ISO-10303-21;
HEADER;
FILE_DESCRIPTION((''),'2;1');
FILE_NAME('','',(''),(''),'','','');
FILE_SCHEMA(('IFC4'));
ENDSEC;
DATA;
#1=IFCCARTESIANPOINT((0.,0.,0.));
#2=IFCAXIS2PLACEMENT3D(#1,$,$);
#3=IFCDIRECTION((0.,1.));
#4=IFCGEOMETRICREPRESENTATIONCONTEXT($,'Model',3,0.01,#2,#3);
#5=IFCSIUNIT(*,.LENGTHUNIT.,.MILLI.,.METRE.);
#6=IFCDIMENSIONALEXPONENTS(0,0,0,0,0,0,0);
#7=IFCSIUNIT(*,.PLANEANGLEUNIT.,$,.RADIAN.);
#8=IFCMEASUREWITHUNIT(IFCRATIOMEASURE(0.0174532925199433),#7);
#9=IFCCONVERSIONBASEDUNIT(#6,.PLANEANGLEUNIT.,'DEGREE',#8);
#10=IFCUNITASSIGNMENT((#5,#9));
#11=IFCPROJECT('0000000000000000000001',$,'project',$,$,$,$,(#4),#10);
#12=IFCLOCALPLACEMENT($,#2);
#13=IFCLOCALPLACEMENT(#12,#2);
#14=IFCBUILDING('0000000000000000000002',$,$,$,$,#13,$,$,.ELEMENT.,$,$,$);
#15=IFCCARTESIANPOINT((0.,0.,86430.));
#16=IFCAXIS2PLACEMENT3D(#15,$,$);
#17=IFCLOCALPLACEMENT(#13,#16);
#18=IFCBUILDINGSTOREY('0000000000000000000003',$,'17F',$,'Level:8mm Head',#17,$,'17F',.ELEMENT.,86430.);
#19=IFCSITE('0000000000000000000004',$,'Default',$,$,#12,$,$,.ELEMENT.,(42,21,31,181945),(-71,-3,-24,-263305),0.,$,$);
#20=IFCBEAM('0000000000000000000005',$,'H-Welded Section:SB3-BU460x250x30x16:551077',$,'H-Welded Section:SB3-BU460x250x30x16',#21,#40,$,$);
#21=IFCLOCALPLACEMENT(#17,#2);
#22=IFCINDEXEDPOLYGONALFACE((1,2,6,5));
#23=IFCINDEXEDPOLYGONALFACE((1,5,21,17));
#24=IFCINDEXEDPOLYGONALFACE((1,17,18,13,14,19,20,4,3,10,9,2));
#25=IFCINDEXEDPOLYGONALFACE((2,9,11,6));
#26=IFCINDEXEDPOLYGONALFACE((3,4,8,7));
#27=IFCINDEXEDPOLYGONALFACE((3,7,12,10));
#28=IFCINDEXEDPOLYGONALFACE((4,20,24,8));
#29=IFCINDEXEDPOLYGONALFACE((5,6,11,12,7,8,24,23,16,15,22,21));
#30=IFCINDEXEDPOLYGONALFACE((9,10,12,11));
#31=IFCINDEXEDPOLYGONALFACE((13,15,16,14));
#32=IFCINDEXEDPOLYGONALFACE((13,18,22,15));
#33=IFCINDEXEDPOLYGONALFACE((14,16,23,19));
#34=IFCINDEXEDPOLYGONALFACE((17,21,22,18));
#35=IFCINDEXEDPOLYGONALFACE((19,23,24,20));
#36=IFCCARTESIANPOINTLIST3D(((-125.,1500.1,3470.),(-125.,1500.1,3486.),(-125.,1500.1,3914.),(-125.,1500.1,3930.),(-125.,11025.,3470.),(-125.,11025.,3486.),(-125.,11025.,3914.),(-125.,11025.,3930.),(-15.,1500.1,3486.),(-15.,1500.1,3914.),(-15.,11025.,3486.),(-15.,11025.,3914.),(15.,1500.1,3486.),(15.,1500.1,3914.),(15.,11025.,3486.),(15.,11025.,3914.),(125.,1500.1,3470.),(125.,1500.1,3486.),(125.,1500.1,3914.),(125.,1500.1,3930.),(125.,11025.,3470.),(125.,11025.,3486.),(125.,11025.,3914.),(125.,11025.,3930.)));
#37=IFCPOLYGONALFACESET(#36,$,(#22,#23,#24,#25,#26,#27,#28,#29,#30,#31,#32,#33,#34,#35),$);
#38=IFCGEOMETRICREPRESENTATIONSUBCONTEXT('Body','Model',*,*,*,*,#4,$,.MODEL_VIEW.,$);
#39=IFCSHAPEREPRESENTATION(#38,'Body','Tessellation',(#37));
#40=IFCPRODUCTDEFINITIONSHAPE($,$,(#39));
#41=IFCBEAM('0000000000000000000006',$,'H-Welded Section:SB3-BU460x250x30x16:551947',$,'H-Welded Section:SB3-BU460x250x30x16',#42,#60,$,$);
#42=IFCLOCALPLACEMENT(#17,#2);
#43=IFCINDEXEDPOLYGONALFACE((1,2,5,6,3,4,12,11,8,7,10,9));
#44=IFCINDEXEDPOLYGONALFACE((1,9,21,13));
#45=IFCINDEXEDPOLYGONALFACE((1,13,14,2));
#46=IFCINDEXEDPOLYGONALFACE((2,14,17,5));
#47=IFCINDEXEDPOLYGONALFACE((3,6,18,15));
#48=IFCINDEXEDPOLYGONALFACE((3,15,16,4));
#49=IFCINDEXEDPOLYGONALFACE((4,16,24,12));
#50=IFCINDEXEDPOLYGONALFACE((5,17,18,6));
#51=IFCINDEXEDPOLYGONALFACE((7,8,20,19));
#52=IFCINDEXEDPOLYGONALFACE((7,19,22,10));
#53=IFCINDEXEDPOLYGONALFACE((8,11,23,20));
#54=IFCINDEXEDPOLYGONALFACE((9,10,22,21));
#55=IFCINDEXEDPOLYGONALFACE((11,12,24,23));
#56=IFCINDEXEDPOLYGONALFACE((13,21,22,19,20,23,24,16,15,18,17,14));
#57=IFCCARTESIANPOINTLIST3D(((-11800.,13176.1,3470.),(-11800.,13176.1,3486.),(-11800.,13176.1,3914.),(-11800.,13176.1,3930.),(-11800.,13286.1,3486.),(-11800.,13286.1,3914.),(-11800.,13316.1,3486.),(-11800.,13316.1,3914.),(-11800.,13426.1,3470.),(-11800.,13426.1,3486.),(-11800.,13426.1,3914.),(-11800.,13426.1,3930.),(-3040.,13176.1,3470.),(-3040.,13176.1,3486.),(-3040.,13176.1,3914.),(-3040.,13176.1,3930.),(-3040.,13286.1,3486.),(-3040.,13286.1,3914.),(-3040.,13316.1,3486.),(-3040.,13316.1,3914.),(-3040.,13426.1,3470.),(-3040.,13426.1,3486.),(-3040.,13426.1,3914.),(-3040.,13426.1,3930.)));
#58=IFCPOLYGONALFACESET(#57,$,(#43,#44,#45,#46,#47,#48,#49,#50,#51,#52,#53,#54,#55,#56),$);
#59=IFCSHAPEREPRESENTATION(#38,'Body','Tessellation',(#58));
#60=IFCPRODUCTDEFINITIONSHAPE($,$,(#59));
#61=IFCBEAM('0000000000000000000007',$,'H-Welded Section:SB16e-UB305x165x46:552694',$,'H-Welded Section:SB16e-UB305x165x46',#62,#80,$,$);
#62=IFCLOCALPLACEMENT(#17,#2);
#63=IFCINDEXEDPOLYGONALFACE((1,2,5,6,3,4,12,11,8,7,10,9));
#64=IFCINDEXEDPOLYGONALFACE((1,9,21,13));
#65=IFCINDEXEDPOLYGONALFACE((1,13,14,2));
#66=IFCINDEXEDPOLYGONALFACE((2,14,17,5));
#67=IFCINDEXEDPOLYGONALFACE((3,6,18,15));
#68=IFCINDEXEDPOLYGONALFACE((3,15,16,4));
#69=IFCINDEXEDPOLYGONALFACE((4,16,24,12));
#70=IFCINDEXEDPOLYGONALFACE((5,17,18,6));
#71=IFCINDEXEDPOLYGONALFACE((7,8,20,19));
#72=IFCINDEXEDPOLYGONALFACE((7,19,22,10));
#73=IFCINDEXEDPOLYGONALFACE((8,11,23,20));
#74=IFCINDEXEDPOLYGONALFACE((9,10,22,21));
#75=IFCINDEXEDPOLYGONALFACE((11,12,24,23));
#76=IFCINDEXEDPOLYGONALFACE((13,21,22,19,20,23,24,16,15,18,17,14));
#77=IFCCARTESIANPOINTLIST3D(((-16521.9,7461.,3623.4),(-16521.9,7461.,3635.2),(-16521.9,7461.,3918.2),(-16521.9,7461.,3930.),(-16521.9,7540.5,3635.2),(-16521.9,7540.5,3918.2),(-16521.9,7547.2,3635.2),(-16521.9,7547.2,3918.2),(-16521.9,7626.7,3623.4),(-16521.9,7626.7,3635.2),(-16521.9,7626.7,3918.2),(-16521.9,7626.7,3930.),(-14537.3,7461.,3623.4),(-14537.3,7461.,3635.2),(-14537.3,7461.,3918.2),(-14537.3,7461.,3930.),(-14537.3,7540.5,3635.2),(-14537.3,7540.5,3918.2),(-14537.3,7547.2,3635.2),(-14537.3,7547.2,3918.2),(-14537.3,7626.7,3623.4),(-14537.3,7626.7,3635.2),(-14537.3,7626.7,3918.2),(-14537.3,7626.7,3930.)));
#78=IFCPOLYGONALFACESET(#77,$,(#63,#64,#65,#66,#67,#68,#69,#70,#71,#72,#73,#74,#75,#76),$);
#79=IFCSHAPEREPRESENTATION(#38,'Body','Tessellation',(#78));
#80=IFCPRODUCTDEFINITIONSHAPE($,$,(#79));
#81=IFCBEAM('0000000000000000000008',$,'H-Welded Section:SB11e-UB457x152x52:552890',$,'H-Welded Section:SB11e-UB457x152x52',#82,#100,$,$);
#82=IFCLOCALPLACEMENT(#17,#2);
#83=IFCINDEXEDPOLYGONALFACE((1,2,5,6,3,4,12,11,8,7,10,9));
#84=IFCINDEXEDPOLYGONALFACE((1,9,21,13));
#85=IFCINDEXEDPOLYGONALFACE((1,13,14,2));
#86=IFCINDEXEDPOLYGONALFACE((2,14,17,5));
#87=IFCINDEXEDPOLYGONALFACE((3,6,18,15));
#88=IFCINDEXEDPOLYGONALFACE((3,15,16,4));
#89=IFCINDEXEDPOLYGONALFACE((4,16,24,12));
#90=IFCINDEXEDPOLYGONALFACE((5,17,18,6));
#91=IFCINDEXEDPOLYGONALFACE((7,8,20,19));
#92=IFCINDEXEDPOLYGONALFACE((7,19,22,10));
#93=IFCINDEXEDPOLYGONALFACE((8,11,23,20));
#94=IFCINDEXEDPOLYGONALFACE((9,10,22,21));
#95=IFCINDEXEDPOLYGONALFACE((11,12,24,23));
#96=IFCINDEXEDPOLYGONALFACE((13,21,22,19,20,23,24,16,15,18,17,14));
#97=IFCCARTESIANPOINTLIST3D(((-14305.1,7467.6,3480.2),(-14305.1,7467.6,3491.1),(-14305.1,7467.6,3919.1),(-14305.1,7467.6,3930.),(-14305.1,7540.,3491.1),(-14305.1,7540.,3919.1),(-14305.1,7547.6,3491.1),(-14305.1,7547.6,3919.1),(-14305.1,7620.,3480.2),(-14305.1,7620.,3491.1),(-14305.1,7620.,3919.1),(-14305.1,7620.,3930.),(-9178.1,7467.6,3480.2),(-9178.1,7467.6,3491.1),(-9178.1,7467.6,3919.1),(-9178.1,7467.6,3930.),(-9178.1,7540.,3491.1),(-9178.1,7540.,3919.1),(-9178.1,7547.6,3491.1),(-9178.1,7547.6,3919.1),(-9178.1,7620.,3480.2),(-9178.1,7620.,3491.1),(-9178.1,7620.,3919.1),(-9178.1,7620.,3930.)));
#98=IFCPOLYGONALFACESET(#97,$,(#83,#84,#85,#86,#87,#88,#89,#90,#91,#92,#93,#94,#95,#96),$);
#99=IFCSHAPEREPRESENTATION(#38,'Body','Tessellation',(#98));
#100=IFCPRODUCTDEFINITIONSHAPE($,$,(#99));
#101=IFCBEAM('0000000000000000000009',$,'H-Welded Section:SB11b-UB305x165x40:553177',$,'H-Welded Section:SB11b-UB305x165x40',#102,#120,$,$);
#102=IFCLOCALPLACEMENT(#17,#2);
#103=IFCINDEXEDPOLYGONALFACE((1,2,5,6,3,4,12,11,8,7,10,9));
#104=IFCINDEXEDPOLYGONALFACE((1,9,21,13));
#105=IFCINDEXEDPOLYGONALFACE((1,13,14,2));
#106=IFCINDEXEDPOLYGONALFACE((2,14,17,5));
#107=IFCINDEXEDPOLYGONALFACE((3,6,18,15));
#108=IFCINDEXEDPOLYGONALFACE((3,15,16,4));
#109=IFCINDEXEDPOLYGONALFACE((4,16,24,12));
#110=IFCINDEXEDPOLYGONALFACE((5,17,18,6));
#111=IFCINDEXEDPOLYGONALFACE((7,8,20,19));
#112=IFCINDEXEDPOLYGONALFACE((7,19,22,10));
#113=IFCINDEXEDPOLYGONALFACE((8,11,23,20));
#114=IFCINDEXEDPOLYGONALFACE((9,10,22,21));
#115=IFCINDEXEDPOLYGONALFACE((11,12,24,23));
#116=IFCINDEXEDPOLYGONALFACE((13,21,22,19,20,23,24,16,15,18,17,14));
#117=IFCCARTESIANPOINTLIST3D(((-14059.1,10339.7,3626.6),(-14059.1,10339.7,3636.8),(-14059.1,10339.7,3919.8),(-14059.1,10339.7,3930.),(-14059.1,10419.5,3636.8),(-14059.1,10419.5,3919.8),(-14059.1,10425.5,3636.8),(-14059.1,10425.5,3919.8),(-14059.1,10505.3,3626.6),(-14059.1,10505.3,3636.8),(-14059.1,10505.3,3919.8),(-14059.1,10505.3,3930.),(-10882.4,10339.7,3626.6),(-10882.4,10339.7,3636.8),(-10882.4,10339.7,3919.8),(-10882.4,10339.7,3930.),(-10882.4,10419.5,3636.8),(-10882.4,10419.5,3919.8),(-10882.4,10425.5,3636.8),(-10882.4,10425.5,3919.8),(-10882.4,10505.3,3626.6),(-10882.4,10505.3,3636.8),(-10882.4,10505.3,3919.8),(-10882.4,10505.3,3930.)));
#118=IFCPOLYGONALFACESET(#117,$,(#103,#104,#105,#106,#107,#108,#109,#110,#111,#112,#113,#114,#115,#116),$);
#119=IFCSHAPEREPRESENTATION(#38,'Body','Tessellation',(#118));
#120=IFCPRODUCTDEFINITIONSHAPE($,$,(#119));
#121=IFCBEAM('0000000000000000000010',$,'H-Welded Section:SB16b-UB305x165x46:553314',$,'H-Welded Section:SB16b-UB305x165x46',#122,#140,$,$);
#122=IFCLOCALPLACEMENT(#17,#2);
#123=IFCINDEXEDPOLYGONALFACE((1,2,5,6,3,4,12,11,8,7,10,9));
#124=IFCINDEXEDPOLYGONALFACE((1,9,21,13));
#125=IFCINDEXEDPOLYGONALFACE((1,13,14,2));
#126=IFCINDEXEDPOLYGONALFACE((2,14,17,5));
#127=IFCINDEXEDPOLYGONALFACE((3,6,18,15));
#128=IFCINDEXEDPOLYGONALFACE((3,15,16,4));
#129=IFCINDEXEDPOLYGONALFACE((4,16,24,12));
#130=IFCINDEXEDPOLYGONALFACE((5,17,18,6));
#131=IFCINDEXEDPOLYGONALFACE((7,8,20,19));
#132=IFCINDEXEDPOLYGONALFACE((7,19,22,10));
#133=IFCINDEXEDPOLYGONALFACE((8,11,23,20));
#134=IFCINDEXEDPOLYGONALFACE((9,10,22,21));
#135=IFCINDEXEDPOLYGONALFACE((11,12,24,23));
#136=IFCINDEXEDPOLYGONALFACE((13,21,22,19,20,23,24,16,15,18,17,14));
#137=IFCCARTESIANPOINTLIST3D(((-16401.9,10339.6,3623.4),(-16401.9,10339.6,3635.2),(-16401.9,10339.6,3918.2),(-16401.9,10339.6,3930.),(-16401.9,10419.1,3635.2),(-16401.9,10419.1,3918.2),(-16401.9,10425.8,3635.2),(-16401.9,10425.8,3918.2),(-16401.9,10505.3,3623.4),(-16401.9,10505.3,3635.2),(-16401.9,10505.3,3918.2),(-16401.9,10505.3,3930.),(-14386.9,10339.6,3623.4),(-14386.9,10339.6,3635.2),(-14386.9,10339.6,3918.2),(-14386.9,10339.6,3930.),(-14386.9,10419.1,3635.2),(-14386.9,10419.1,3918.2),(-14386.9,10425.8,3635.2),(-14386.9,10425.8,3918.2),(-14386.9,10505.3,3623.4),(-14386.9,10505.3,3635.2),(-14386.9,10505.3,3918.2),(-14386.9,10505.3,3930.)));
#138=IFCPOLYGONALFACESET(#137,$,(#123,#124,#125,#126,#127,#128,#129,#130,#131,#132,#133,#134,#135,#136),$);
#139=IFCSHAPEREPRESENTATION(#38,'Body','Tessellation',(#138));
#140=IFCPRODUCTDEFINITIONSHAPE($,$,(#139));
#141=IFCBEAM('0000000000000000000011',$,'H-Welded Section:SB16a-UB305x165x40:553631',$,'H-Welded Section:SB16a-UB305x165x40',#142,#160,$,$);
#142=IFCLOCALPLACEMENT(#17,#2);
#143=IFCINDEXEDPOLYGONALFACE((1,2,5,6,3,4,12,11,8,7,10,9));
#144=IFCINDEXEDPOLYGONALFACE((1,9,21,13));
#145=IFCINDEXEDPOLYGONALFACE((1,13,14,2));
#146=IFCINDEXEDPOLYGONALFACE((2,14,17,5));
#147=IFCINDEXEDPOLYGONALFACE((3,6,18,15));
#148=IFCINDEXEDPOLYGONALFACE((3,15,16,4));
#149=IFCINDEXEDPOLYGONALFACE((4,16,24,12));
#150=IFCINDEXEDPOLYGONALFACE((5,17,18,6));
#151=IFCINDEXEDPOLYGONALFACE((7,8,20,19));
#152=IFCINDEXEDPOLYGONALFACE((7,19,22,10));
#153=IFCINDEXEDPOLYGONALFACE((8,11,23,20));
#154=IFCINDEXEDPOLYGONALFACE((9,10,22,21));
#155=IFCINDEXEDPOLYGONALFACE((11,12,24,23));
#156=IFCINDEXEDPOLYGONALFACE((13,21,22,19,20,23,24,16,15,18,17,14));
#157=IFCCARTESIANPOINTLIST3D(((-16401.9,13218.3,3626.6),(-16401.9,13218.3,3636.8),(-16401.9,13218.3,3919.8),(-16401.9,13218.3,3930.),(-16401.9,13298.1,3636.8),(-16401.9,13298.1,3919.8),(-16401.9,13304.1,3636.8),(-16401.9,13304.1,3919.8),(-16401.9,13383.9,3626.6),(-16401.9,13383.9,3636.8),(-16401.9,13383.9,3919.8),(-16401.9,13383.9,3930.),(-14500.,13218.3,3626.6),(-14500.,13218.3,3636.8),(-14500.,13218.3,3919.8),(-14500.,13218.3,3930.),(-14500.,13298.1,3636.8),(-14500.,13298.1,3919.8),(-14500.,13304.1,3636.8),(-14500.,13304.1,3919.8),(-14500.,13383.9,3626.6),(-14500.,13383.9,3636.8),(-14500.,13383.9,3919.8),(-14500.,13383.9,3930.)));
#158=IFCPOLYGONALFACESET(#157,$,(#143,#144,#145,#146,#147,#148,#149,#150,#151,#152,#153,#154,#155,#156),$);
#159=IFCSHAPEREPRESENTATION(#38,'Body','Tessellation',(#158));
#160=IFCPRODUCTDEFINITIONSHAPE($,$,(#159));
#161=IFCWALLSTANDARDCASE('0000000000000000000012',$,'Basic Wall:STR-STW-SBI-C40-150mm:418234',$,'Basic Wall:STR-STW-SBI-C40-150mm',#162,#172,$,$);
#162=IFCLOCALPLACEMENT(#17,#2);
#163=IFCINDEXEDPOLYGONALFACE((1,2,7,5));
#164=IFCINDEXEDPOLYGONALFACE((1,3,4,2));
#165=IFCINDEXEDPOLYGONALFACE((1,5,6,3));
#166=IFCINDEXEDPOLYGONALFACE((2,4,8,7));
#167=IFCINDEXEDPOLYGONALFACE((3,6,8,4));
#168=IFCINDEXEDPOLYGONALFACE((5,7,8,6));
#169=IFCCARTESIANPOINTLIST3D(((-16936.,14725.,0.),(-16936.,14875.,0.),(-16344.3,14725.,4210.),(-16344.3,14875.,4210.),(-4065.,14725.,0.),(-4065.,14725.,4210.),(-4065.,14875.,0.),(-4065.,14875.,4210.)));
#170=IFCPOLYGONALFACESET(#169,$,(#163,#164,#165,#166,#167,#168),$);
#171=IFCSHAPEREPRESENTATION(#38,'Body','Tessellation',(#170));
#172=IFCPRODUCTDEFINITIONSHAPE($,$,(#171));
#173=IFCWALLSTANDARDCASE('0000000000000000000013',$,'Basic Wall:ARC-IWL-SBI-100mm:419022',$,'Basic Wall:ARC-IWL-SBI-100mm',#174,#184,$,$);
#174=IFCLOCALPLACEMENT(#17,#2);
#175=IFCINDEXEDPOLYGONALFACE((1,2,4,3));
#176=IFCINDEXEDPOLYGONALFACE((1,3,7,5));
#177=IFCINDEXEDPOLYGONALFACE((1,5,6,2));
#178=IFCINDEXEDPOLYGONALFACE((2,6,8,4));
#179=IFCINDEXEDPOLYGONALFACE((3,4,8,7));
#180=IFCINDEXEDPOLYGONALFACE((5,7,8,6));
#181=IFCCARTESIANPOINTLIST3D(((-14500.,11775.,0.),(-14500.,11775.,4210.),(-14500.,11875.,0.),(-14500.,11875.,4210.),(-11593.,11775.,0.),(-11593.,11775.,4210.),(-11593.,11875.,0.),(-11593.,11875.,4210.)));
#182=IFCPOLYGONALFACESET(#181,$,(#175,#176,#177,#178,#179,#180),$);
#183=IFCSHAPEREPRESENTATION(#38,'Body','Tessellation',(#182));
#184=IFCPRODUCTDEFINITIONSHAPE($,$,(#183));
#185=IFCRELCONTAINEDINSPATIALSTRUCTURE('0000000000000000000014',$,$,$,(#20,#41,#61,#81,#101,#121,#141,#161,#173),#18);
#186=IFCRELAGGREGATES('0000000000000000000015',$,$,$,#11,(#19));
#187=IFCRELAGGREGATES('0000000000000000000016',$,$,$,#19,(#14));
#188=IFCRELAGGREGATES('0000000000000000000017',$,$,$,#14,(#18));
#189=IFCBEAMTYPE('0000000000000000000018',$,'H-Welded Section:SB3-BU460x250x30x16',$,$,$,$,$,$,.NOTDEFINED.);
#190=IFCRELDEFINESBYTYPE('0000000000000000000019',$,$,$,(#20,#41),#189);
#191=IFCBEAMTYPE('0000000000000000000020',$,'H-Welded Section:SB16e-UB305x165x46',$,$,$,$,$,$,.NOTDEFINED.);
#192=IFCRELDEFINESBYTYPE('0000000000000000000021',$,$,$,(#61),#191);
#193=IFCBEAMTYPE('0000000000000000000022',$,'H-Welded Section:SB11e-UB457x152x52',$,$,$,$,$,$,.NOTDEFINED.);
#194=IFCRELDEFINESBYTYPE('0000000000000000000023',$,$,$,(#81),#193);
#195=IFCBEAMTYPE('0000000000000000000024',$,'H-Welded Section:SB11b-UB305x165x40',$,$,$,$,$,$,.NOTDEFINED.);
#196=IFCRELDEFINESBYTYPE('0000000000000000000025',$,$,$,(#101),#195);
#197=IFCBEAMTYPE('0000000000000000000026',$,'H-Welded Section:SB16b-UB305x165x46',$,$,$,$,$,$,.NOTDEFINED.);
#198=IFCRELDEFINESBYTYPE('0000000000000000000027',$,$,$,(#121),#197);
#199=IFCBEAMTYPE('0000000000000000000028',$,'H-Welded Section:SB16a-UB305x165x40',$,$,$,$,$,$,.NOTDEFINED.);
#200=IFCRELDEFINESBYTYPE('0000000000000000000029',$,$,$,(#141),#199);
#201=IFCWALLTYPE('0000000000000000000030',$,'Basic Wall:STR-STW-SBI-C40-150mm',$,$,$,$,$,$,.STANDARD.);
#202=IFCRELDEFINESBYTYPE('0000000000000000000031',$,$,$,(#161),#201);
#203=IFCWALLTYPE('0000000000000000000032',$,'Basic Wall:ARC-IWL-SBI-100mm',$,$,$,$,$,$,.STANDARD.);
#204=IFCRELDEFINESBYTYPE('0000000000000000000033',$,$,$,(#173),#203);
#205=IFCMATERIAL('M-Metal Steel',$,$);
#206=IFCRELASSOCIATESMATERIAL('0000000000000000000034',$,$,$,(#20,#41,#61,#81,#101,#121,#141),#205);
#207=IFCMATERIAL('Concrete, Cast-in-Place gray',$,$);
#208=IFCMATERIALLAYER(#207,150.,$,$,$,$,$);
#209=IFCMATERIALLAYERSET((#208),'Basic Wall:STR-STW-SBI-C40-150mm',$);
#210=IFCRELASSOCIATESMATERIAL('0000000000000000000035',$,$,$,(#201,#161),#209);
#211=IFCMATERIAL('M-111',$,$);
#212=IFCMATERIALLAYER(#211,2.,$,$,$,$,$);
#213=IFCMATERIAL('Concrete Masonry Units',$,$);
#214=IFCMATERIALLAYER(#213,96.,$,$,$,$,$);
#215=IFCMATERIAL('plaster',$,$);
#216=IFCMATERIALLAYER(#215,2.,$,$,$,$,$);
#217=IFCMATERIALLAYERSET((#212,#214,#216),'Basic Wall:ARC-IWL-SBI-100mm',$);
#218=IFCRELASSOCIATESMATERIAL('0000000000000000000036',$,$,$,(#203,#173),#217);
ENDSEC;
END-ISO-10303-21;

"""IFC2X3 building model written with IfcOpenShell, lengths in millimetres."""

from ifc_helpers import new_model, entity, si_unit, converted_unit, direction, frame, frame_2d, origin, place, context, subcontext, project, spatial, rectangle, i_section, extrude, clip, halfspace, material, layer, layer_set, layer_usage, type_object, element, save


model = new_model("IFC2X3")

# Units and contexts
model_context = context("Model", 3, precision=0.01, world=origin(), true_north=direction((0.0, 1.0)))
body_context = subcontext(model_context, "Body", "Model", "MODEL_VIEW")
ifc_project = project(units=[si_unit("LENGTHUNIT", "METRE", prefix="MILLI"), converted_unit("PLANEANGLEUNIT", "DEGREE", entity("IfcRatioMeasure", 0.0174532925199433), si_unit("PLANEANGLEUNIT", "RADIAN"), dimensions=[0, 0, 0, 0, 0, 0, 0])], contexts=[model_context])

# Site, building, storey
site_placement = place(None, origin())
site = spatial("IfcSite", under=ifc_project, at=site_placement, Name="Default", CompositionType="ELEMENT", RefLatitude=(42, 21, 31, 181945), RefLongitude=(-71, -3, -24, -263305), RefElevation=0.0)
building_placement = place(site_placement, origin())
building = spatial("IfcBuilding", under=site, at=building_placement, CompositionType="ELEMENT")
storey_placement = place(building_placement, frame((0.0, 0.0, 86430.0)))
storey = spatial("IfcBuildingStorey", under=building, at=storey_placement, Name="17F", ObjectType="Level:8mm Head", LongName="17F", CompositionType="ELEMENT", Elevation=86430.0)

# Beams
ifc_material_1 = material(Name="M-Metal Steel")
beam_type_1 = type_object("IfcBeamType", Name="H-Welded Section:SB3-BU460x250x30x16", PredefinedType="NOTDEFINED")
beam_1_placement = place(storey_placement, frame((0.0, 11025.0, 0.0), z_axis=(0.0, 0.0, 1.0), x_axis=(0.0, -1.0, 0.0)))
element("IfcBeam", 1, at=beam_1_placement, inside=storey, type_object=beam_type_1, material=ifc_material_1, Name="H-Welded Section:SB3-BU460x250x30x16:551077", ObjectType="H-Welded Section:SB3-BU460x250x30x16", context=body_context, shape_type="SweptSolid", body=[
    extrude(i_section(OverallWidth=250.0, OverallDepth=460.0, WebThickness=30.0, FlangeThickness=16.0, at=frame_2d((0.0, 0.0), x_axis=(0.0, 1.0))), frame((0.0, 0.0, 3700.0), z_axis=(1.0, 0.0, 0.0), x_axis=(0.0, 0.0, -1.0)), (0.0, 0.0, 1.0), 9524.9),
])
beam_2_placement = place(storey_placement, frame((-13377.3, 13301.1, 0.0)))
element("IfcBeam", 2, at=beam_2_placement, inside=storey, type_object=beam_type_1, material=ifc_material_1, Name="H-Welded Section:SB3-BU460x250x30x16:551947", ObjectType="H-Welded Section:SB3-BU460x250x30x16", context=body_context, shape_type="SweptSolid", body=[
    extrude(i_section(OverallWidth=250.0, OverallDepth=460.0, WebThickness=30.0, FlangeThickness=16.0, at=frame_2d((0.0, 0.0), x_axis=(0.0, 1.0))), frame((1577.3, 0.0, 3700.0), z_axis=(1.0, 0.0, 0.0), x_axis=(0.0, 0.0, -1.0)), (0.0, 0.0, 1.0), 8760.0),
])
beam_type_2 = type_object("IfcBeamType", Name="H-Welded Section:SB16e-UB305x165x46", PredefinedType="NOTDEFINED")
beam_3_placement = place(storey_placement, frame((-16537.3, 7543.8, 0.0)))
element("IfcBeam", 3, at=beam_3_placement, inside=storey, type_object=beam_type_2, material=ifc_material_1, Name="H-Welded Section:SB16e-UB305x165x46:552694", ObjectType="H-Welded Section:SB16e-UB305x165x46", context=body_context, shape_type="SweptSolid", body=[
    extrude(i_section(OverallWidth=165.7, OverallDepth=306.6, WebThickness=6.7, FlangeThickness=11.8, at=frame_2d((0.0, 0.0), x_axis=(0.0, 1.0))), frame((15.3, 0.0, 3776.7), z_axis=(1.0, 0.0, 0.0), x_axis=(0.0, 0.0, -1.0)), (0.0, 0.0, 1.0), 1984.7),
])
beam_type_3 = type_object("IfcBeamType", Name="H-Welded Section:SB11e-UB457x152x52", PredefinedType="NOTDEFINED")
beam_4_placement = place(storey_placement, frame((-14325.6, 7543.8, 0.0)))
element("IfcBeam", 4, at=beam_4_placement, inside=storey, type_object=beam_type_3, material=ifc_material_1, Name="H-Welded Section:SB11e-UB457x152x52:552890", ObjectType="H-Welded Section:SB11e-UB457x152x52", context=body_context, shape_type="SweptSolid", body=[
    extrude(i_section(OverallWidth=152.4, OverallDepth=449.8, WebThickness=7.6, FlangeThickness=10.9, at=frame_2d((0.0, 0.0), x_axis=(0.0, 1.0))), frame((20.5, 0.0, 3705.1), z_axis=(1.0, 0.0, 0.0), x_axis=(0.0, 0.0, -1.0)), (0.0, 0.0, 1.0), 5126.9),
])
beam_type_4 = type_object("IfcBeamType", Name="H-Welded Section:SB11b-UB305x165x40", PredefinedType="NOTDEFINED")
beam_5_placement = place(storey_placement, frame((-14224.9, 10422.5, 0.0)))
element("IfcBeam", 5, at=beam_5_placement, inside=storey, type_object=beam_type_4, material=ifc_material_1, Name="H-Welded Section:SB11b-UB305x165x40:553177", ObjectType="H-Welded Section:SB11b-UB305x165x40", context=body_context, shape_type="SweptSolid", body=[
    extrude(i_section(OverallWidth=165.6, OverallDepth=303.4, WebThickness=6.0, FlangeThickness=10.2, at=frame_2d((0.0, 0.0), x_axis=(0.0, 1.0))), frame((165.8, 0.0, 3778.3), z_axis=(1.0, 0.0, 0.0), x_axis=(0.0, 0.0, -1.0)), (0.0, 0.0, 1.0), 3176.7),
])
beam_type_5 = type_object("IfcBeamType", Name="H-Welded Section:SB16b-UB305x165x46", PredefinedType="NOTDEFINED")
beam_6_placement = place(storey_placement, frame((-16524.9, 10422.5, 0.0)))
element("IfcBeam", 6, at=beam_6_placement, inside=storey, type_object=beam_type_5, material=ifc_material_1, Name="H-Welded Section:SB16b-UB305x165x46:553314", ObjectType="H-Welded Section:SB16b-UB305x165x46", context=body_context, shape_type="SweptSolid", body=[
    extrude(i_section(OverallWidth=165.7, OverallDepth=306.6, WebThickness=6.7, FlangeThickness=11.8, at=frame_2d((0.0, 0.0), x_axis=(0.0, 1.0))), frame((123.0, 0.0, 3776.7), z_axis=(1.0, 0.0, 0.0), x_axis=(0.0, 0.0, -1.0)), (0.0, 0.0, 1.0), 2015.0),
])
beam_type_6 = type_object("IfcBeamType", Name="H-Welded Section:SB16a-UB305x165x40", PredefinedType="NOTDEFINED")
beam_7_placement = place(storey_placement, frame((-16445.9, 13301.1, 0.0)))
element("IfcBeam", 7, at=beam_7_placement, inside=storey, type_object=beam_type_6, material=ifc_material_1, Name="H-Welded Section:SB16a-UB305x165x40:553631", ObjectType="H-Welded Section:SB16a-UB305x165x40", context=body_context, shape_type="SweptSolid", body=[
    extrude(i_section(OverallWidth=165.6, OverallDepth=303.4, WebThickness=6.0, FlangeThickness=10.2, at=frame_2d((0.0, 0.0), x_axis=(0.0, 1.0))), frame((44.0, 0.0, 3778.3), z_axis=(1.0, 0.0, 0.0), x_axis=(0.0, 0.0, -1.0)), (0.0, 0.0, 1.0), 1901.9),
])

# Walls
ifc_material_2 = material(Name="Concrete, Cast-in-Place gray")
ifc_layer_1 = layer(ifc_material_2, 150.0)
ifc_layer_set_1 = layer_set([ifc_layer_1], Name="Basic Wall:STR-STW-SBI-C40-150mm")
ifc_layer_usage_1 = layer_usage(ifc_layer_set_1, "AXIS2", "NEGATIVE", 75.0)
wall_type_1 = type_object("IfcWallType", Name="Basic Wall:STR-STW-SBI-C40-150mm", PredefinedType="STANDARD", material=ifc_layer_set_1)
wall_1_placement = place(storey_placement, frame((-16936.0, 14800.0, 0.0)))
element("IfcWallStandardCase", 8, at=wall_1_placement, inside=storey, type_object=wall_type_1, material=ifc_layer_usage_1, Name="Basic Wall:STR-STW-SBI-C40-150mm:418234", ObjectType="Basic Wall:STR-STW-SBI-C40-150mm", context=body_context, shape_type="Clipping", body=[
    clip(extrude(rectangle(XDim=12871.0, YDim=150.0, at=frame_2d((6435.5, 0.0), x_axis=(-1.0, 0.0))), origin(), (0.0, 0.0, 1.0), 4210.0), halfspace(frame((0.0, -75.0, 0.0), z_axis=(-0.990268, 0.0, 0.139173), x_axis=(0.0, 1.0, 0.0)), False)),
])
ifc_material_3 = material(Name="M-111")
ifc_layer_2 = layer(ifc_material_3, 2.0)
ifc_material_4 = material(Name="Concrete Masonry Units")
ifc_layer_3 = layer(ifc_material_4, 96.0)
ifc_material_5 = material(Name="plaster")
ifc_layer_4 = layer(ifc_material_5, 2.0)
ifc_layer_set_2 = layer_set([ifc_layer_2, ifc_layer_3, ifc_layer_4], Name="Basic Wall:ARC-IWL-SBI-100mm")
ifc_layer_usage_2 = layer_usage(ifc_layer_set_2, "AXIS2", "NEGATIVE", 50.0)
wall_type_2 = type_object("IfcWallType", Name="Basic Wall:ARC-IWL-SBI-100mm", PredefinedType="STANDARD", material=ifc_layer_set_2)
wall_2_placement = place(storey_placement, frame((-11593.0, 11825.0, 0.0), z_axis=(0.0, 0.0, 1.0), x_axis=(-1.0, 0.0, 0.0)))
element("IfcWallStandardCase", 9, at=wall_2_placement, inside=storey, type_object=wall_type_2, material=ifc_layer_usage_2, Name="Basic Wall:ARC-IWL-SBI-100mm:419022", ObjectType="Basic Wall:ARC-IWL-SBI-100mm", context=body_context, shape_type="SweptSolid", body=[
    extrude(rectangle(XDim=2907.0, YDim=100.0, at=frame_2d((1453.5, 0.0), x_axis=(-1.0, 0.0))), origin(), (0.0, 0.0, 1.0), 4210.0),
])

save(model, "model.ifc")
